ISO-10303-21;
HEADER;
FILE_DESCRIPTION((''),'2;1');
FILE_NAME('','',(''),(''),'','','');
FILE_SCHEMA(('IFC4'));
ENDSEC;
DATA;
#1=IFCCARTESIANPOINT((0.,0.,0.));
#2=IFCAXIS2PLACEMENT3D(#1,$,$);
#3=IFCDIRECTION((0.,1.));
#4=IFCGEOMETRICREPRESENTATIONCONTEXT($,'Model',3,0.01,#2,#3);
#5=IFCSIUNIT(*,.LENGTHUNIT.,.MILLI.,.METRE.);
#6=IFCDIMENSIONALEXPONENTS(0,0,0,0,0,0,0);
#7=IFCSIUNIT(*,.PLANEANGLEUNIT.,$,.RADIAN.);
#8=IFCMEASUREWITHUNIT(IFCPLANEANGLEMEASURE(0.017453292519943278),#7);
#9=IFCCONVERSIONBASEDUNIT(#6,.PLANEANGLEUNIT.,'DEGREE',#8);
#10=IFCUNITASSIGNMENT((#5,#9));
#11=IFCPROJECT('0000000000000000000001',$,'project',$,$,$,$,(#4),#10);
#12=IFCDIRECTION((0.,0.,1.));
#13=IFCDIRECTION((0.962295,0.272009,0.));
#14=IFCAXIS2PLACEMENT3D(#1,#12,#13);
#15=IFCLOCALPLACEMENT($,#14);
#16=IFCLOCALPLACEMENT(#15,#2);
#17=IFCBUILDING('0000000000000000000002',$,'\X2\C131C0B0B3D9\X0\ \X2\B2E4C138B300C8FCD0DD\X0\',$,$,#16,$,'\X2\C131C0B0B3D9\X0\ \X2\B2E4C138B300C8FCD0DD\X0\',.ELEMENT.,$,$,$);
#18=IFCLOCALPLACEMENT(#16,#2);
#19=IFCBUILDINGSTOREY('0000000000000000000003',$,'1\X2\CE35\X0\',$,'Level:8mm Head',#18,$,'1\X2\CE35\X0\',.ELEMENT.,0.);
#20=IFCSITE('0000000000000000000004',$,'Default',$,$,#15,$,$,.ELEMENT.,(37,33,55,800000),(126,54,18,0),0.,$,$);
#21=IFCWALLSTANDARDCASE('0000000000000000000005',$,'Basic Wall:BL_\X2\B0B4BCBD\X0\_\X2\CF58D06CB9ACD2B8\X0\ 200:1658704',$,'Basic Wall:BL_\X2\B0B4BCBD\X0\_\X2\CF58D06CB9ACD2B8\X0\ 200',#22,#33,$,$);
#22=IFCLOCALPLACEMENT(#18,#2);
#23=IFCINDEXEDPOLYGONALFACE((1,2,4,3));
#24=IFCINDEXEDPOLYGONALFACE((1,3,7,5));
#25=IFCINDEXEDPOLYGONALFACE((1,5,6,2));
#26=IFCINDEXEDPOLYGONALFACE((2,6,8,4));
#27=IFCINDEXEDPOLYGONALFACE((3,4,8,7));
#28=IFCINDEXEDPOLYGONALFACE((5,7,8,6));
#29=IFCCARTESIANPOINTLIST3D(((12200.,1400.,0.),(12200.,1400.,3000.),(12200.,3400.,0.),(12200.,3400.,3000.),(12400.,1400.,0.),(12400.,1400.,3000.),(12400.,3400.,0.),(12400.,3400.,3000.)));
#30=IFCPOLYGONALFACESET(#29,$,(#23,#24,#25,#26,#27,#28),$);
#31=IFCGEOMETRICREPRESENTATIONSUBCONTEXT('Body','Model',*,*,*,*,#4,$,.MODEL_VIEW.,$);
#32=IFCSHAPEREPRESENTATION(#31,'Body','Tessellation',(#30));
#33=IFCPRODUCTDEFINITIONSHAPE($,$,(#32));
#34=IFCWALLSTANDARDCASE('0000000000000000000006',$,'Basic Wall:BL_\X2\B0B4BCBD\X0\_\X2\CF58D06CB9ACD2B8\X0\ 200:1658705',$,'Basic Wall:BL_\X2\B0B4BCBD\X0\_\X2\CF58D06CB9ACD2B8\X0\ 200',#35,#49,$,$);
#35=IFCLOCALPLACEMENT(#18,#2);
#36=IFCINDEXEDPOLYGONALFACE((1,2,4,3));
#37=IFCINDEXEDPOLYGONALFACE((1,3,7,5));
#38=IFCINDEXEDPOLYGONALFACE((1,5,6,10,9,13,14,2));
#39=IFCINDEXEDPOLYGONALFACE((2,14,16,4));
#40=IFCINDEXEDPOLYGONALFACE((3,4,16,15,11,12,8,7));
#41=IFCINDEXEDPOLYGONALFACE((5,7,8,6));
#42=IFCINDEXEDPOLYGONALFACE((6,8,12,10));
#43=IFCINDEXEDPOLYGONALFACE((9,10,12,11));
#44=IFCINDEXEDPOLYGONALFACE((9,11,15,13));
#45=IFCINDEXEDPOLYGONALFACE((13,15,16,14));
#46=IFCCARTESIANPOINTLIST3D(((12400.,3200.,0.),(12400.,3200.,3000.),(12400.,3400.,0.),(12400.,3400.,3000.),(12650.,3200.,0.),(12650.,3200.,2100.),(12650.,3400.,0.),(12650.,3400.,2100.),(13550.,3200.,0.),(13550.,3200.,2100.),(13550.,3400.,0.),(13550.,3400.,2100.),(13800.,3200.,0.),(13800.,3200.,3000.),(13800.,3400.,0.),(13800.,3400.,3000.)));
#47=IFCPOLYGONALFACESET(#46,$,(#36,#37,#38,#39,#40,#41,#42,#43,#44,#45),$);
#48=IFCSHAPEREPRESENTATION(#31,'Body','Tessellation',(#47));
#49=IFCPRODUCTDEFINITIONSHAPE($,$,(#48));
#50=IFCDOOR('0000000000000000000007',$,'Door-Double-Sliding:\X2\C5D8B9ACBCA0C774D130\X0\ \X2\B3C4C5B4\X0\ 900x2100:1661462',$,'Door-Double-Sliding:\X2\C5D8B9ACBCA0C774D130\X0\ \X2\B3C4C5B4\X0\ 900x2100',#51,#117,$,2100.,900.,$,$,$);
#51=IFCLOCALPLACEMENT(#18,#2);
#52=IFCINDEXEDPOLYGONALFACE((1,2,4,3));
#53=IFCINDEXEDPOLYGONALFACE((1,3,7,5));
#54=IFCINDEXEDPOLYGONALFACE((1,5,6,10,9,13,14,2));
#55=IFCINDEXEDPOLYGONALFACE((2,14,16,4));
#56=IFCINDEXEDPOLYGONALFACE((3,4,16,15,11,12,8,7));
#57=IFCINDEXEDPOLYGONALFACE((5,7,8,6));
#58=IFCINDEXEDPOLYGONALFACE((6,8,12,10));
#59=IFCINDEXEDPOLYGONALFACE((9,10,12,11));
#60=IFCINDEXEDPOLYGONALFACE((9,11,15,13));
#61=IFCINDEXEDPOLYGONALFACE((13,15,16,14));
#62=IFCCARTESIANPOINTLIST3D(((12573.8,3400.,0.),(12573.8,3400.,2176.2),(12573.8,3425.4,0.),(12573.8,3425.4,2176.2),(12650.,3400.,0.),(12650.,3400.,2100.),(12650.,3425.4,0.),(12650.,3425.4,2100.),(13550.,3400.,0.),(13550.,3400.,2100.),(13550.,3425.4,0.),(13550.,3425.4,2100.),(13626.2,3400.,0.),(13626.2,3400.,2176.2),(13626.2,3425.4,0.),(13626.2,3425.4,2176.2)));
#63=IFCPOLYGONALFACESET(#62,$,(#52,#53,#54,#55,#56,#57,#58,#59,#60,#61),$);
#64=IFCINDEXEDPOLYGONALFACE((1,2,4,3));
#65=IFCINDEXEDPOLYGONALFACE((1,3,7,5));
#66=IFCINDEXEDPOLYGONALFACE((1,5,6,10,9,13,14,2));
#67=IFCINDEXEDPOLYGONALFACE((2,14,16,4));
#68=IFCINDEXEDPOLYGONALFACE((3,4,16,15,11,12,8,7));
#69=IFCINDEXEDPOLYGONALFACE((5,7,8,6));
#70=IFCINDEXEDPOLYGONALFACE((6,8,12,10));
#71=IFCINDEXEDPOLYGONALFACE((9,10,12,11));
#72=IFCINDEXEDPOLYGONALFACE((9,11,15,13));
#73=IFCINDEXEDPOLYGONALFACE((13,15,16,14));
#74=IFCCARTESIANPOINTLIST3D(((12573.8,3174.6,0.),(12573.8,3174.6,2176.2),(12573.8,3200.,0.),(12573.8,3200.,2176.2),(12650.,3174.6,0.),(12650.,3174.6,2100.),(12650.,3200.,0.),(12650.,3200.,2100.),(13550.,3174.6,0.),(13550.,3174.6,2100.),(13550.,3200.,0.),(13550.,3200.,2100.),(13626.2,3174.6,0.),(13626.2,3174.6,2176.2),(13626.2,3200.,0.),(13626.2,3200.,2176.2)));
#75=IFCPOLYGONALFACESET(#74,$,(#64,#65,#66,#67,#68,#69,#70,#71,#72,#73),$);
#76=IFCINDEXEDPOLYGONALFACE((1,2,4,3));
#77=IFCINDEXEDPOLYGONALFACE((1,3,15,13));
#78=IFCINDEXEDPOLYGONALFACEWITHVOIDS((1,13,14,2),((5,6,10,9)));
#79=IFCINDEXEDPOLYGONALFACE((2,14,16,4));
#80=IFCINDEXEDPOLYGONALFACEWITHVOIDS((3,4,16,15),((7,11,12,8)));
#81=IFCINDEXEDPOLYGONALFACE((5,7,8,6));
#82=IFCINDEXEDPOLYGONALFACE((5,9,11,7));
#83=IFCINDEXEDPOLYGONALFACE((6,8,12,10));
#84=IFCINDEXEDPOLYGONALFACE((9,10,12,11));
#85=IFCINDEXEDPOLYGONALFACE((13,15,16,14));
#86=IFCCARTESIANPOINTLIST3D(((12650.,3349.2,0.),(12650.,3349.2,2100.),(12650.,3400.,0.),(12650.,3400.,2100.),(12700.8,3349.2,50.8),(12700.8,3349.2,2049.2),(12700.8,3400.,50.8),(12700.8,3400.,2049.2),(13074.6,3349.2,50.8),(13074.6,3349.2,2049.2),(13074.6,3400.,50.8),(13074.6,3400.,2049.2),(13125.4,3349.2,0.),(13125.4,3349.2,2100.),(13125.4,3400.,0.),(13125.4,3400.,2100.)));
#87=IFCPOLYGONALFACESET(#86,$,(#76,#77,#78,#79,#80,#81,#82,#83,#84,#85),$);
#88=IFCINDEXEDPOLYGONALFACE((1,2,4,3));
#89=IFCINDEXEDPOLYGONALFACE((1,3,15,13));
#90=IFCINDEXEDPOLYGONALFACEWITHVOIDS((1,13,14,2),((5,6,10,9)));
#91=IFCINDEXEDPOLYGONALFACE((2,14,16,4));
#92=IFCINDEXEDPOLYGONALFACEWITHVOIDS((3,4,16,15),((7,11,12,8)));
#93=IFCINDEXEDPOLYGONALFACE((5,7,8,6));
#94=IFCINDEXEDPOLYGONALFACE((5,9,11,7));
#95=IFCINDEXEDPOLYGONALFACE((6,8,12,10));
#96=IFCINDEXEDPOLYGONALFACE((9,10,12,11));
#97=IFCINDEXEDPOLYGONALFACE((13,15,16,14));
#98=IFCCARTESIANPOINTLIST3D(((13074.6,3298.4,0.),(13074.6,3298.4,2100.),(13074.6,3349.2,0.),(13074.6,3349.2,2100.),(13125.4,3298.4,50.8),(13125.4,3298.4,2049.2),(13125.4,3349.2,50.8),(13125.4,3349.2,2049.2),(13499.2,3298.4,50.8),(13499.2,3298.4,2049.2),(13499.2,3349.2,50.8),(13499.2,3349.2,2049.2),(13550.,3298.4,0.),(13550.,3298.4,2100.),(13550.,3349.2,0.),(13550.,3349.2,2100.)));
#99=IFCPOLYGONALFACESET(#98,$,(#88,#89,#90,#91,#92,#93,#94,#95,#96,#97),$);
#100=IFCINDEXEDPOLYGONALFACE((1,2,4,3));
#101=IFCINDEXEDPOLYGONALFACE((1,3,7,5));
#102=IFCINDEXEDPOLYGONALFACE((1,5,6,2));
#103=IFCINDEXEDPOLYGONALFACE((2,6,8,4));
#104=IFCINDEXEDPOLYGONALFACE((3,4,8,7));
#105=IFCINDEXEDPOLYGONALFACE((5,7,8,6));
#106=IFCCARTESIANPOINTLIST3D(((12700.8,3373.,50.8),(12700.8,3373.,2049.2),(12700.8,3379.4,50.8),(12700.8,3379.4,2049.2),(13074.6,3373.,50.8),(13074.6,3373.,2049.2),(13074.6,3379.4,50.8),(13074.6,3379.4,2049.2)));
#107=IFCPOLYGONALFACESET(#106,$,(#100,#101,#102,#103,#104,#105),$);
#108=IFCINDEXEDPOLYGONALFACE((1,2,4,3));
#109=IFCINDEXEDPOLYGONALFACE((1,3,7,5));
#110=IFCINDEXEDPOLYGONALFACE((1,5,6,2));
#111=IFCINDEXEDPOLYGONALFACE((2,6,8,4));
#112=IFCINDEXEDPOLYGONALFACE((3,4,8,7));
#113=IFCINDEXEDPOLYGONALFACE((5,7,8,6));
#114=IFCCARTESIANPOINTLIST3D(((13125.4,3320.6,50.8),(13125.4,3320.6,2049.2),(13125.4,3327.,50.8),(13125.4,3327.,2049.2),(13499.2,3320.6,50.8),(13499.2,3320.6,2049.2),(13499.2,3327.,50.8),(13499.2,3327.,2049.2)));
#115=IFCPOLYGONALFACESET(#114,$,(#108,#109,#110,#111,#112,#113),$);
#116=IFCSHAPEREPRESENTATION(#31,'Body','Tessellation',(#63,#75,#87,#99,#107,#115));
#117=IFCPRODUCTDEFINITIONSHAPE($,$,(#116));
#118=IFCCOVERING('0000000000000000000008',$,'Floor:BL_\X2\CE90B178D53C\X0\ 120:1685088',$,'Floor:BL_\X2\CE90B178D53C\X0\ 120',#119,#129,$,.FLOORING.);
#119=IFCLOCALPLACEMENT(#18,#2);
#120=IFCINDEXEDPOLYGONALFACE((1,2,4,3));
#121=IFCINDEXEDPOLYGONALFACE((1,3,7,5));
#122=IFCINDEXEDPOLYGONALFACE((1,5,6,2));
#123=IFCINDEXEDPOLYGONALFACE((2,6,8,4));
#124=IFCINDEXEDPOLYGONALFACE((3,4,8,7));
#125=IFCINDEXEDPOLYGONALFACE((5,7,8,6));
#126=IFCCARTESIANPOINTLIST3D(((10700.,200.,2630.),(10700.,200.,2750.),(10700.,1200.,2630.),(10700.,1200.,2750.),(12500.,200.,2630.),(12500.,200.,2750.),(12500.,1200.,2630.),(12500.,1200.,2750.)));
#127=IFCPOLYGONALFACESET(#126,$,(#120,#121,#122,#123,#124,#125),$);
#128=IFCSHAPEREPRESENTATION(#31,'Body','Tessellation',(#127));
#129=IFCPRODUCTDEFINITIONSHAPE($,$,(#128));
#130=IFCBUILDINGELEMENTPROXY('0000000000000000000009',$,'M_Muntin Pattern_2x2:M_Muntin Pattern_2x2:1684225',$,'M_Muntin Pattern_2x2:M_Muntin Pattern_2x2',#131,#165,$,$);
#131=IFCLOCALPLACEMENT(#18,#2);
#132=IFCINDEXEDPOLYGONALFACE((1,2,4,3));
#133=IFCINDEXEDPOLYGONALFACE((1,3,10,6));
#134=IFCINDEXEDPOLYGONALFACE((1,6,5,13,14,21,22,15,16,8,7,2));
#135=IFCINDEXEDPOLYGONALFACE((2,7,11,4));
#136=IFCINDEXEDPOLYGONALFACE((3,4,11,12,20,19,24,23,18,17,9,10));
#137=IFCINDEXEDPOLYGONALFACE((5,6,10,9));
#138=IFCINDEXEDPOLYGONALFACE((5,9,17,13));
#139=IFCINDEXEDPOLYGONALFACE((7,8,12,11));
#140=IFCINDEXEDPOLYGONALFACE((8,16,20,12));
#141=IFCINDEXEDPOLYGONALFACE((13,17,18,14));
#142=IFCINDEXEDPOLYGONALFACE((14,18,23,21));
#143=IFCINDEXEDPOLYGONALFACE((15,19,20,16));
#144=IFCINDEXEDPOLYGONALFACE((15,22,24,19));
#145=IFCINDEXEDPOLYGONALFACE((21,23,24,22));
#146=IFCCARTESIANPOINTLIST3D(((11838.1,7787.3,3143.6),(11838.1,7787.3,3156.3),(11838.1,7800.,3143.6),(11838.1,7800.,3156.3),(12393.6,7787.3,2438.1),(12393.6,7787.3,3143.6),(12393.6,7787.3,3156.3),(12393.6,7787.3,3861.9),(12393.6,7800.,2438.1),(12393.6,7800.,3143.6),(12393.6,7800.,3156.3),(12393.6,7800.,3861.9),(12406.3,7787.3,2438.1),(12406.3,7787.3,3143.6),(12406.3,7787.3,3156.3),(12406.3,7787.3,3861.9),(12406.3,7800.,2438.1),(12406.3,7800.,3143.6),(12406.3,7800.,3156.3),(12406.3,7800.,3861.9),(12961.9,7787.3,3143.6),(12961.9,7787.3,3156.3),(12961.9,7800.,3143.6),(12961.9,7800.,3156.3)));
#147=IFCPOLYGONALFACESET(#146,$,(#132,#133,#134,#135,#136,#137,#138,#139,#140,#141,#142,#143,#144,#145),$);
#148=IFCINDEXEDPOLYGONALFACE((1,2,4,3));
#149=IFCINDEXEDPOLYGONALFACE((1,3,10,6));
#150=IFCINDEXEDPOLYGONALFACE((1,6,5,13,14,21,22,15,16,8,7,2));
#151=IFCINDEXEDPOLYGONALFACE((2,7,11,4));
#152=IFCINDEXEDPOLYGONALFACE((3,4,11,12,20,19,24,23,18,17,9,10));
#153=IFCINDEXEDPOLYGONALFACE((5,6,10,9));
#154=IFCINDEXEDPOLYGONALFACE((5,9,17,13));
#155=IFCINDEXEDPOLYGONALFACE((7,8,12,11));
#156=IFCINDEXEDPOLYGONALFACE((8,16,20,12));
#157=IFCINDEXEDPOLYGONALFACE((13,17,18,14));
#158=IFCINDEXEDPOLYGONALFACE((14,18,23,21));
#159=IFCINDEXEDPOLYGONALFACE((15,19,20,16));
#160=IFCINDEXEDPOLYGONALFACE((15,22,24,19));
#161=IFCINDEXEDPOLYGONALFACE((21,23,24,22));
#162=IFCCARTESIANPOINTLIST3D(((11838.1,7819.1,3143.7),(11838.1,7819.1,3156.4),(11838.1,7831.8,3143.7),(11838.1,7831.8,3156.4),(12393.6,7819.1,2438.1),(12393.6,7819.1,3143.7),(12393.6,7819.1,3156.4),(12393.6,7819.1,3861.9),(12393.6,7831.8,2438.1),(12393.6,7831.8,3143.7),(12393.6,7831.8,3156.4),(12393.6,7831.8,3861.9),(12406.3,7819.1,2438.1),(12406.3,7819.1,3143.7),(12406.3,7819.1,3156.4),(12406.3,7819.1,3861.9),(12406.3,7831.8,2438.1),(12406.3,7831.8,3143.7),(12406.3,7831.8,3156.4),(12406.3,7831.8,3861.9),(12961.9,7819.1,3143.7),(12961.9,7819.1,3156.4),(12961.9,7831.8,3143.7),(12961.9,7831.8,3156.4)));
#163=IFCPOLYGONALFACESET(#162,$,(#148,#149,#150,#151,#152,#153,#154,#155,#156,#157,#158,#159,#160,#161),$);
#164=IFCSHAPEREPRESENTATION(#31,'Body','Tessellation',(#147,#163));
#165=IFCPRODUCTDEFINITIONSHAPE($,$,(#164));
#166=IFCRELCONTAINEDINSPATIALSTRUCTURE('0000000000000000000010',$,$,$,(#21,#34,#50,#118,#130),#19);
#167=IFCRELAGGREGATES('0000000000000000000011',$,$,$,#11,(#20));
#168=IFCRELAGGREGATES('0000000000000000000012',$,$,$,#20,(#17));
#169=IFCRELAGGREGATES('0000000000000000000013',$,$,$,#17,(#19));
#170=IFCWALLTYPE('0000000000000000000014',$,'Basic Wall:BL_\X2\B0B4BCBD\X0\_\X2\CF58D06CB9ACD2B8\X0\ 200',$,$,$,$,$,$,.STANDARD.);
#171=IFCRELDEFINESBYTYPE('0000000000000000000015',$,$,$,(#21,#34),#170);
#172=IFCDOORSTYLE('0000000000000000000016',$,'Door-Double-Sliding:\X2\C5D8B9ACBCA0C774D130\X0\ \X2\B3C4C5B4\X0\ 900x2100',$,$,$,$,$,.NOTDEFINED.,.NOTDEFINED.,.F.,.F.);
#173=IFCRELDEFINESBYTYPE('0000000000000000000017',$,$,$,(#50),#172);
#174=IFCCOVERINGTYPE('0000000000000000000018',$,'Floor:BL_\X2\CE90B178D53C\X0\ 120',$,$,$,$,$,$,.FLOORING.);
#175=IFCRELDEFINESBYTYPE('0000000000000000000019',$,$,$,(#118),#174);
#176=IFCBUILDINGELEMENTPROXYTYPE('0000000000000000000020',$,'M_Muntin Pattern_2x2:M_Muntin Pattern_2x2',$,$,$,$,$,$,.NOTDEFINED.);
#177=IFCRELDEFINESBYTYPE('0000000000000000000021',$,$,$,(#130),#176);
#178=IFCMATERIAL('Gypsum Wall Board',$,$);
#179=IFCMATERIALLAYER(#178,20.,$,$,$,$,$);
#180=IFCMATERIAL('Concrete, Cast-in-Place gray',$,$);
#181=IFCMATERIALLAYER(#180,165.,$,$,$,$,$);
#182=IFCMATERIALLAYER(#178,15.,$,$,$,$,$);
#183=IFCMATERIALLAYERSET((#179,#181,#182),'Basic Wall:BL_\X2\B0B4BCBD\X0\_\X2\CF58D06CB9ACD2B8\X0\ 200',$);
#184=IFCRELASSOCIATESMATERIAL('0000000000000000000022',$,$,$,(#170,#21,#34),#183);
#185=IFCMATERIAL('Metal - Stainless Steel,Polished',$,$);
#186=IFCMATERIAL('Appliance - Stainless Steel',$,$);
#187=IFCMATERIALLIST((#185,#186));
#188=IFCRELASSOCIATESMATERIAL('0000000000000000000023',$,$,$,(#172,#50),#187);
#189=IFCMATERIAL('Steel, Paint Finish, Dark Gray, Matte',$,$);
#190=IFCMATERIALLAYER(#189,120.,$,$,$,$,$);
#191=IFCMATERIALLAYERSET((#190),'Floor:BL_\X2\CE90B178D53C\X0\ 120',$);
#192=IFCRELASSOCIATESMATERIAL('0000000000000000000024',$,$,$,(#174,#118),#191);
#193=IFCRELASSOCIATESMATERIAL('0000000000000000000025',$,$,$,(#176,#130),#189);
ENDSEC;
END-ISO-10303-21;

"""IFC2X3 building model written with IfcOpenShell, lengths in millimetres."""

from ifc_helpers import new_model, entity, si_unit, converted_unit, direction, frame, frame_2d, origin, place, context, subcontext, project, spatial, polyline, rectangle, outline, extrude, source, transform, mapped, material, material_list, layer, layer_set, layer_usage, type_object, type_shapes, element, fill, save


model = new_model("IFC2X3")

# Units and contexts
model_context = context("Model", 3, precision=0.01, world=origin(), true_north=direction((0.0, 1.0)))
body_context = subcontext(model_context, "Body", "Model", "MODEL_VIEW")
ifc_project = project(units=[si_unit("LENGTHUNIT", "METRE", prefix="MILLI"), converted_unit("PLANEANGLEUNIT", "DEGREE", entity("IfcPlaneAngleMeasure", 0.017453292519943278), si_unit("PLANEANGLEUNIT", "RADIAN"), dimensions=[0, 0, 0, 0, 0, 0, 0])], contexts=[model_context])

# Site, building, storey
site_placement = place(None, frame((0.0, 0.0, 0.0), z_axis=(0.0, 0.0, 1.0), x_axis=(0.962295, 0.272009, 0.0)))
site = spatial("IfcSite", under=ifc_project, at=site_placement, Name="Default", CompositionType="ELEMENT", RefLatitude=(37, 33, 55, 800000), RefLongitude=(126, 54, 18, 0), RefElevation=0.0)
building_placement = place(site_placement, origin())
building = spatial("IfcBuilding", under=site, at=building_placement, Name="성산동 다세대주택", LongName="성산동 다세대주택", CompositionType="ELEMENT")
storey_placement = place(building_placement, origin())
storey = spatial("IfcBuildingStorey", under=building, at=storey_placement, Name="1층", ObjectType="Level:8mm Head", LongName="1층", CompositionType="ELEMENT", Elevation=0.0)

# Shared definitions
ifc_material_1 = material(Name="Concrete, Cast-in-Place gray")

# Shared definitions
ifc_material_2 = material(Name="Steel, Paint Finish, Dark Gray, Matte")
ifc_material_3 = material(Name="Gypsum Wall Board")

# Wall
ifc_layer_1 = layer(ifc_material_3, 20.0)
ifc_layer_2 = layer(ifc_material_1, 165.0)
ifc_layer_3 = layer(ifc_material_3, 15.0)
ifc_layer_set_1 = layer_set([ifc_layer_1, ifc_layer_2, ifc_layer_3], Name="Basic Wall:BL_내벽_콘크리트 200")
ifc_layer_usage_1 = layer_usage(ifc_layer_set_1, "AXIS2", "NEGATIVE", 100.0)
wall_type_1 = type_object("IfcWallType", Name="Basic Wall:BL_내벽_콘크리트 200", PredefinedType="STANDARD", material=ifc_layer_set_1)
wall_1_placement = place(storey_placement, frame((12300.0, 1400.0, 0.0), z_axis=(0.0, 0.0, 1.0), x_axis=(0.0, 1.0, 0.0)))
element("IfcWallStandardCase", 1, at=wall_1_placement, inside=storey, type_object=wall_type_1, material=ifc_layer_usage_1, Name="Basic Wall:BL_내벽_콘크리트 200:1658704", ObjectType="Basic Wall:BL_내벽_콘크리트 200", context=body_context, shape_type="SweptSolid", body=[
    extrude(rectangle(XDim=2000.0, YDim=200.0, at=frame_2d((1000.0, 0.0), x_axis=(-1.0, 0.0))), origin(), (0.0, 0.0, 1.0), 3000.0),
])

# Wall, opening, door
ifc_layer_usage_2 = layer_usage(ifc_layer_set_1, "AXIS2", "NEGATIVE", 100.0)
wall_2_placement = place(storey_placement, frame((12400.0, 3300.0, 0.0)))
wall_2 = element("IfcWallStandardCase", 2, at=wall_2_placement, inside=storey, type_object=wall_type_1, material=ifc_layer_usage_2, Name="Basic Wall:BL_내벽_콘크리트 200:1658705", ObjectType="Basic Wall:BL_내벽_콘크리트 200", context=body_context, shape_type="SweptSolid", body=[
    extrude(rectangle(XDim=1400.0, YDim=200.0, at=frame_2d((700.0, 0.0), x_axis=(1.0, 0.0))), origin(), (0.0, 0.0, 1.0), 3000.0),
])
opening_1_placement = place(wall_2_placement, frame((250.0, -100.0, 0.0)))
opening_1 = element("IfcOpeningElement", 3, at=opening_1_placement, cuts=wall_2, ObjectType="Opening", context=body_context, shape_type="SweptSolid", body=[
    extrude(rectangle(XDim=2100.0, YDim=900.0, at=frame_2d((1050.0, 450.0), x_axis=(-1.0, 0.0))), frame((0.0, 0.0, 0.0), z_axis=(0.0, 1.0, 0.0), x_axis=(0.0, 0.0, 1.0)), (0.0, 0.0, 1.0), 200.0),
])
ifc_material_4 = material(Name="Metal - Stainless Steel,Polished")
ifc_material_5 = material(Name="Appliance - Stainless Steel")
ifc_material_list_1 = material_list([ifc_material_4, ifc_material_5])
door_style_1 = type_object("IfcDoorStyle", Name="Door-Double-Sliding:엘리베이터 도어 900x2100", ConstructionType="NOTDEFINED", OperationType="NOTDEFINED", ParameterTakesPrecedence=False, Sizeable=False, material=ifc_material_list_1)
shared_shape_1 = source(origin(), body_context, "Body", "SweptSolid", [
    extrude(outline(polyline([(-526.2, -1069.1), (-450.0, -1069.1), (-450.0, 1030.9), (450.0, 1031.0), (450.0, -1069.0), (526.2, -1069.0), (526.2, 1107.1), (-526.2, 1107.1), (-526.2, -1069.1)])), frame((450.0, 200.0, 1069.0), z_axis=(0.0, 1.0, 0.0), x_axis=(-1.0, 0.0, 0.0)), (0.0, 0.0, 1.0), 25.4),
    extrude(outline(polyline([(-1069.0, -526.2), (1107.1, -526.2), (1107.1, 526.2), (-1069.0, 526.2), (-1069.0, 450.0), (1030.9, 450.0), (1030.9, -450.0), (-1069.0, -450.0), (-1069.0, -526.2)])), frame((450.0, -25.4, 1069.0), z_axis=(0.0, 1.0, 0.0), x_axis=(0.0, 0.0, 1.0)), (0.0, 0.0, 1.0), 25.4),
    extrude(outline(polyline([(-1050.0, -237.7), (1050.0, -237.7), (1050.0, 237.7), (-1050.0, 237.7), (-1050.0, -237.7)]), holes=[polyline([(-999.2, -186.9), (-999.2, 186.9), (999.2, 186.9), (999.2, -186.9), (-999.2, -186.9)])]), frame((237.7, 149.2, 1050.0), z_axis=(0.0, 1.0, 0.0), x_axis=(0.0, 0.0, -1.0)), (0.0, 0.0, 1.0), 50.8),
    extrude(outline(polyline([(-237.7, -1050.0), (237.7, -1050.0), (237.7, 1050.0), (-237.7, 1050.0), (-237.7, -1050.0)]), holes=[polyline([(-186.9, -999.2), (-186.9, 999.2), (186.9, 999.2), (186.9, -999.2), (-186.9, -999.2)])]), frame((662.3, 98.4, 1050.0), z_axis=(0.0, 1.0, 0.0), x_axis=(1.0, 0.0, 0.0)), (0.0, 0.0, 1.0), 50.8),
    extrude(rectangle(XDim=6.4, YDim=373.8, at=frame_2d((0.0, 0.0), x_axis=(1.0, 0.0))), frame((237.7, 176.2, 50.8), z_axis=(0.0, 0.0, 1.0), x_axis=(0.0, 1.0, 0.0)), (0.0, 0.0, 1.0), 1998.4),
    extrude(rectangle(XDim=6.3, YDim=373.8, at=frame_2d((0.0, 0.0), x_axis=(1.0, 0.0))), frame((662.3, 123.8, 50.8), z_axis=(0.0, 0.0, 1.0), x_axis=(0.0, -1.0, 0.0)), (0.0, 0.0, 1.0), 1998.4),
])
type_shapes(door_style_1, [shared_shape_1])
door_1_placement = place(opening_1_placement, origin())
door_1 = element("IfcDoor", 4, at=door_1_placement, inside=storey, type_object=door_style_1, material=ifc_material_list_1, Name="Door-Double-Sliding:엘리베이터 도어 900x2100:1661462", ObjectType="Door-Double-Sliding:엘리베이터 도어 900x2100", OverallHeight=2100.0, OverallWidth=900.0, context=body_context, shape_type="MappedRepresentation", body=[
    mapped(shared_shape_1, transform((0.0, 0.0, 0.0), scale=1.0)),
])
fill(opening_1, door_1)

# Covering
ifc_layer_4 = layer(ifc_material_2, 120.0)
ifc_layer_set_2 = layer_set([ifc_layer_4], Name="Floor:BL_캐노피 120")
ifc_layer_usage_3 = layer_usage(ifc_layer_set_2, "AXIS3", "POSITIVE", 0.0)
covering_type = type_object("IfcCoveringType", Name="Floor:BL_캐노피 120", PredefinedType="FLOORING", material=ifc_layer_set_2)
covering_placement = place(storey_placement, origin())
element("IfcCovering", 5, at=covering_placement, inside=storey, type_object=covering_type, material=ifc_layer_usage_3, Name="Floor:BL_캐노피 120:1685088", ObjectType="Floor:BL_캐노피 120", PredefinedType="FLOORING", context=body_context, shape_type="SweptSolid", body=[
    extrude(rectangle(XDim=1000.0, YDim=1800.0, at=frame_2d((0.0, 0.0), x_axis=(1.0, 0.0))), frame((11600.0, 700.0, 2750.0), z_axis=(0.0, 0.0, -1.0), x_axis=(0.0, 1.0, 0.0)), (0.0, 0.0, 1.0), 120.0),
])

# Building element proxy
building_element_proxy_type_1 = type_object("IfcBuildingElementProxyType", Name="M_Muntin Pattern_2x2:M_Muntin Pattern_2x2", PredefinedType="NOTDEFINED", material=ifc_material_2)
shared_shape_2 = source(origin(), body_context, "Body", "SweptSolid", [
    extrude(outline(polyline([(6.4, -6.4), (711.9, -6.4), (711.9, 6.3), (6.4, 6.3), (6.4, 561.9), (-6.3, 561.9), (-6.3, 6.3), (-711.9, 6.3), (-711.9, -6.4), (-6.3, -6.4), (-6.3, -561.9), (6.4, -561.9), (6.4, -6.4)])), frame((0.0, -22.2, 711.9), z_axis=(0.0, 1.0, 0.0), x_axis=(0.0, 0.0, 1.0)), (0.0, 0.0, 1.0), 12.7),
    extrude(outline(polyline([(6.4, -6.4), (711.9, -6.4), (711.9, 6.3), (6.4, 6.3), (6.4, 561.9), (-6.3, 561.9), (-6.3, 6.3), (-711.9, 6.3), (-711.9, -6.4), (-6.3, -6.4), (-6.3, -561.9), (6.4, -561.9), (6.4, -6.4)])), frame((0.0, 9.5, 711.9), z_axis=(0.0, 1.0, 0.0), x_axis=(0.0, 0.0, 1.0)), (0.0, 0.0, 1.0), 12.7),
])
type_shapes(building_element_proxy_type_1, [shared_shape_2])
proxy_1_placement = place(storey_placement, frame((12400.0, 7809.5, 2438.1)))
element("IfcBuildingElementProxy", 6, at=proxy_1_placement, inside=storey, type_object=building_element_proxy_type_1, material=ifc_material_2, Name="M_Muntin Pattern_2x2:M_Muntin Pattern_2x2:1684225", ObjectType="M_Muntin Pattern_2x2:M_Muntin Pattern_2x2", context=body_context, shape_type="MappedRepresentation", body=[
    mapped(shared_shape_2, transform((0.0, 0.0, 0.0), scale=1.0)),
])

save(model, "model.ifc")
